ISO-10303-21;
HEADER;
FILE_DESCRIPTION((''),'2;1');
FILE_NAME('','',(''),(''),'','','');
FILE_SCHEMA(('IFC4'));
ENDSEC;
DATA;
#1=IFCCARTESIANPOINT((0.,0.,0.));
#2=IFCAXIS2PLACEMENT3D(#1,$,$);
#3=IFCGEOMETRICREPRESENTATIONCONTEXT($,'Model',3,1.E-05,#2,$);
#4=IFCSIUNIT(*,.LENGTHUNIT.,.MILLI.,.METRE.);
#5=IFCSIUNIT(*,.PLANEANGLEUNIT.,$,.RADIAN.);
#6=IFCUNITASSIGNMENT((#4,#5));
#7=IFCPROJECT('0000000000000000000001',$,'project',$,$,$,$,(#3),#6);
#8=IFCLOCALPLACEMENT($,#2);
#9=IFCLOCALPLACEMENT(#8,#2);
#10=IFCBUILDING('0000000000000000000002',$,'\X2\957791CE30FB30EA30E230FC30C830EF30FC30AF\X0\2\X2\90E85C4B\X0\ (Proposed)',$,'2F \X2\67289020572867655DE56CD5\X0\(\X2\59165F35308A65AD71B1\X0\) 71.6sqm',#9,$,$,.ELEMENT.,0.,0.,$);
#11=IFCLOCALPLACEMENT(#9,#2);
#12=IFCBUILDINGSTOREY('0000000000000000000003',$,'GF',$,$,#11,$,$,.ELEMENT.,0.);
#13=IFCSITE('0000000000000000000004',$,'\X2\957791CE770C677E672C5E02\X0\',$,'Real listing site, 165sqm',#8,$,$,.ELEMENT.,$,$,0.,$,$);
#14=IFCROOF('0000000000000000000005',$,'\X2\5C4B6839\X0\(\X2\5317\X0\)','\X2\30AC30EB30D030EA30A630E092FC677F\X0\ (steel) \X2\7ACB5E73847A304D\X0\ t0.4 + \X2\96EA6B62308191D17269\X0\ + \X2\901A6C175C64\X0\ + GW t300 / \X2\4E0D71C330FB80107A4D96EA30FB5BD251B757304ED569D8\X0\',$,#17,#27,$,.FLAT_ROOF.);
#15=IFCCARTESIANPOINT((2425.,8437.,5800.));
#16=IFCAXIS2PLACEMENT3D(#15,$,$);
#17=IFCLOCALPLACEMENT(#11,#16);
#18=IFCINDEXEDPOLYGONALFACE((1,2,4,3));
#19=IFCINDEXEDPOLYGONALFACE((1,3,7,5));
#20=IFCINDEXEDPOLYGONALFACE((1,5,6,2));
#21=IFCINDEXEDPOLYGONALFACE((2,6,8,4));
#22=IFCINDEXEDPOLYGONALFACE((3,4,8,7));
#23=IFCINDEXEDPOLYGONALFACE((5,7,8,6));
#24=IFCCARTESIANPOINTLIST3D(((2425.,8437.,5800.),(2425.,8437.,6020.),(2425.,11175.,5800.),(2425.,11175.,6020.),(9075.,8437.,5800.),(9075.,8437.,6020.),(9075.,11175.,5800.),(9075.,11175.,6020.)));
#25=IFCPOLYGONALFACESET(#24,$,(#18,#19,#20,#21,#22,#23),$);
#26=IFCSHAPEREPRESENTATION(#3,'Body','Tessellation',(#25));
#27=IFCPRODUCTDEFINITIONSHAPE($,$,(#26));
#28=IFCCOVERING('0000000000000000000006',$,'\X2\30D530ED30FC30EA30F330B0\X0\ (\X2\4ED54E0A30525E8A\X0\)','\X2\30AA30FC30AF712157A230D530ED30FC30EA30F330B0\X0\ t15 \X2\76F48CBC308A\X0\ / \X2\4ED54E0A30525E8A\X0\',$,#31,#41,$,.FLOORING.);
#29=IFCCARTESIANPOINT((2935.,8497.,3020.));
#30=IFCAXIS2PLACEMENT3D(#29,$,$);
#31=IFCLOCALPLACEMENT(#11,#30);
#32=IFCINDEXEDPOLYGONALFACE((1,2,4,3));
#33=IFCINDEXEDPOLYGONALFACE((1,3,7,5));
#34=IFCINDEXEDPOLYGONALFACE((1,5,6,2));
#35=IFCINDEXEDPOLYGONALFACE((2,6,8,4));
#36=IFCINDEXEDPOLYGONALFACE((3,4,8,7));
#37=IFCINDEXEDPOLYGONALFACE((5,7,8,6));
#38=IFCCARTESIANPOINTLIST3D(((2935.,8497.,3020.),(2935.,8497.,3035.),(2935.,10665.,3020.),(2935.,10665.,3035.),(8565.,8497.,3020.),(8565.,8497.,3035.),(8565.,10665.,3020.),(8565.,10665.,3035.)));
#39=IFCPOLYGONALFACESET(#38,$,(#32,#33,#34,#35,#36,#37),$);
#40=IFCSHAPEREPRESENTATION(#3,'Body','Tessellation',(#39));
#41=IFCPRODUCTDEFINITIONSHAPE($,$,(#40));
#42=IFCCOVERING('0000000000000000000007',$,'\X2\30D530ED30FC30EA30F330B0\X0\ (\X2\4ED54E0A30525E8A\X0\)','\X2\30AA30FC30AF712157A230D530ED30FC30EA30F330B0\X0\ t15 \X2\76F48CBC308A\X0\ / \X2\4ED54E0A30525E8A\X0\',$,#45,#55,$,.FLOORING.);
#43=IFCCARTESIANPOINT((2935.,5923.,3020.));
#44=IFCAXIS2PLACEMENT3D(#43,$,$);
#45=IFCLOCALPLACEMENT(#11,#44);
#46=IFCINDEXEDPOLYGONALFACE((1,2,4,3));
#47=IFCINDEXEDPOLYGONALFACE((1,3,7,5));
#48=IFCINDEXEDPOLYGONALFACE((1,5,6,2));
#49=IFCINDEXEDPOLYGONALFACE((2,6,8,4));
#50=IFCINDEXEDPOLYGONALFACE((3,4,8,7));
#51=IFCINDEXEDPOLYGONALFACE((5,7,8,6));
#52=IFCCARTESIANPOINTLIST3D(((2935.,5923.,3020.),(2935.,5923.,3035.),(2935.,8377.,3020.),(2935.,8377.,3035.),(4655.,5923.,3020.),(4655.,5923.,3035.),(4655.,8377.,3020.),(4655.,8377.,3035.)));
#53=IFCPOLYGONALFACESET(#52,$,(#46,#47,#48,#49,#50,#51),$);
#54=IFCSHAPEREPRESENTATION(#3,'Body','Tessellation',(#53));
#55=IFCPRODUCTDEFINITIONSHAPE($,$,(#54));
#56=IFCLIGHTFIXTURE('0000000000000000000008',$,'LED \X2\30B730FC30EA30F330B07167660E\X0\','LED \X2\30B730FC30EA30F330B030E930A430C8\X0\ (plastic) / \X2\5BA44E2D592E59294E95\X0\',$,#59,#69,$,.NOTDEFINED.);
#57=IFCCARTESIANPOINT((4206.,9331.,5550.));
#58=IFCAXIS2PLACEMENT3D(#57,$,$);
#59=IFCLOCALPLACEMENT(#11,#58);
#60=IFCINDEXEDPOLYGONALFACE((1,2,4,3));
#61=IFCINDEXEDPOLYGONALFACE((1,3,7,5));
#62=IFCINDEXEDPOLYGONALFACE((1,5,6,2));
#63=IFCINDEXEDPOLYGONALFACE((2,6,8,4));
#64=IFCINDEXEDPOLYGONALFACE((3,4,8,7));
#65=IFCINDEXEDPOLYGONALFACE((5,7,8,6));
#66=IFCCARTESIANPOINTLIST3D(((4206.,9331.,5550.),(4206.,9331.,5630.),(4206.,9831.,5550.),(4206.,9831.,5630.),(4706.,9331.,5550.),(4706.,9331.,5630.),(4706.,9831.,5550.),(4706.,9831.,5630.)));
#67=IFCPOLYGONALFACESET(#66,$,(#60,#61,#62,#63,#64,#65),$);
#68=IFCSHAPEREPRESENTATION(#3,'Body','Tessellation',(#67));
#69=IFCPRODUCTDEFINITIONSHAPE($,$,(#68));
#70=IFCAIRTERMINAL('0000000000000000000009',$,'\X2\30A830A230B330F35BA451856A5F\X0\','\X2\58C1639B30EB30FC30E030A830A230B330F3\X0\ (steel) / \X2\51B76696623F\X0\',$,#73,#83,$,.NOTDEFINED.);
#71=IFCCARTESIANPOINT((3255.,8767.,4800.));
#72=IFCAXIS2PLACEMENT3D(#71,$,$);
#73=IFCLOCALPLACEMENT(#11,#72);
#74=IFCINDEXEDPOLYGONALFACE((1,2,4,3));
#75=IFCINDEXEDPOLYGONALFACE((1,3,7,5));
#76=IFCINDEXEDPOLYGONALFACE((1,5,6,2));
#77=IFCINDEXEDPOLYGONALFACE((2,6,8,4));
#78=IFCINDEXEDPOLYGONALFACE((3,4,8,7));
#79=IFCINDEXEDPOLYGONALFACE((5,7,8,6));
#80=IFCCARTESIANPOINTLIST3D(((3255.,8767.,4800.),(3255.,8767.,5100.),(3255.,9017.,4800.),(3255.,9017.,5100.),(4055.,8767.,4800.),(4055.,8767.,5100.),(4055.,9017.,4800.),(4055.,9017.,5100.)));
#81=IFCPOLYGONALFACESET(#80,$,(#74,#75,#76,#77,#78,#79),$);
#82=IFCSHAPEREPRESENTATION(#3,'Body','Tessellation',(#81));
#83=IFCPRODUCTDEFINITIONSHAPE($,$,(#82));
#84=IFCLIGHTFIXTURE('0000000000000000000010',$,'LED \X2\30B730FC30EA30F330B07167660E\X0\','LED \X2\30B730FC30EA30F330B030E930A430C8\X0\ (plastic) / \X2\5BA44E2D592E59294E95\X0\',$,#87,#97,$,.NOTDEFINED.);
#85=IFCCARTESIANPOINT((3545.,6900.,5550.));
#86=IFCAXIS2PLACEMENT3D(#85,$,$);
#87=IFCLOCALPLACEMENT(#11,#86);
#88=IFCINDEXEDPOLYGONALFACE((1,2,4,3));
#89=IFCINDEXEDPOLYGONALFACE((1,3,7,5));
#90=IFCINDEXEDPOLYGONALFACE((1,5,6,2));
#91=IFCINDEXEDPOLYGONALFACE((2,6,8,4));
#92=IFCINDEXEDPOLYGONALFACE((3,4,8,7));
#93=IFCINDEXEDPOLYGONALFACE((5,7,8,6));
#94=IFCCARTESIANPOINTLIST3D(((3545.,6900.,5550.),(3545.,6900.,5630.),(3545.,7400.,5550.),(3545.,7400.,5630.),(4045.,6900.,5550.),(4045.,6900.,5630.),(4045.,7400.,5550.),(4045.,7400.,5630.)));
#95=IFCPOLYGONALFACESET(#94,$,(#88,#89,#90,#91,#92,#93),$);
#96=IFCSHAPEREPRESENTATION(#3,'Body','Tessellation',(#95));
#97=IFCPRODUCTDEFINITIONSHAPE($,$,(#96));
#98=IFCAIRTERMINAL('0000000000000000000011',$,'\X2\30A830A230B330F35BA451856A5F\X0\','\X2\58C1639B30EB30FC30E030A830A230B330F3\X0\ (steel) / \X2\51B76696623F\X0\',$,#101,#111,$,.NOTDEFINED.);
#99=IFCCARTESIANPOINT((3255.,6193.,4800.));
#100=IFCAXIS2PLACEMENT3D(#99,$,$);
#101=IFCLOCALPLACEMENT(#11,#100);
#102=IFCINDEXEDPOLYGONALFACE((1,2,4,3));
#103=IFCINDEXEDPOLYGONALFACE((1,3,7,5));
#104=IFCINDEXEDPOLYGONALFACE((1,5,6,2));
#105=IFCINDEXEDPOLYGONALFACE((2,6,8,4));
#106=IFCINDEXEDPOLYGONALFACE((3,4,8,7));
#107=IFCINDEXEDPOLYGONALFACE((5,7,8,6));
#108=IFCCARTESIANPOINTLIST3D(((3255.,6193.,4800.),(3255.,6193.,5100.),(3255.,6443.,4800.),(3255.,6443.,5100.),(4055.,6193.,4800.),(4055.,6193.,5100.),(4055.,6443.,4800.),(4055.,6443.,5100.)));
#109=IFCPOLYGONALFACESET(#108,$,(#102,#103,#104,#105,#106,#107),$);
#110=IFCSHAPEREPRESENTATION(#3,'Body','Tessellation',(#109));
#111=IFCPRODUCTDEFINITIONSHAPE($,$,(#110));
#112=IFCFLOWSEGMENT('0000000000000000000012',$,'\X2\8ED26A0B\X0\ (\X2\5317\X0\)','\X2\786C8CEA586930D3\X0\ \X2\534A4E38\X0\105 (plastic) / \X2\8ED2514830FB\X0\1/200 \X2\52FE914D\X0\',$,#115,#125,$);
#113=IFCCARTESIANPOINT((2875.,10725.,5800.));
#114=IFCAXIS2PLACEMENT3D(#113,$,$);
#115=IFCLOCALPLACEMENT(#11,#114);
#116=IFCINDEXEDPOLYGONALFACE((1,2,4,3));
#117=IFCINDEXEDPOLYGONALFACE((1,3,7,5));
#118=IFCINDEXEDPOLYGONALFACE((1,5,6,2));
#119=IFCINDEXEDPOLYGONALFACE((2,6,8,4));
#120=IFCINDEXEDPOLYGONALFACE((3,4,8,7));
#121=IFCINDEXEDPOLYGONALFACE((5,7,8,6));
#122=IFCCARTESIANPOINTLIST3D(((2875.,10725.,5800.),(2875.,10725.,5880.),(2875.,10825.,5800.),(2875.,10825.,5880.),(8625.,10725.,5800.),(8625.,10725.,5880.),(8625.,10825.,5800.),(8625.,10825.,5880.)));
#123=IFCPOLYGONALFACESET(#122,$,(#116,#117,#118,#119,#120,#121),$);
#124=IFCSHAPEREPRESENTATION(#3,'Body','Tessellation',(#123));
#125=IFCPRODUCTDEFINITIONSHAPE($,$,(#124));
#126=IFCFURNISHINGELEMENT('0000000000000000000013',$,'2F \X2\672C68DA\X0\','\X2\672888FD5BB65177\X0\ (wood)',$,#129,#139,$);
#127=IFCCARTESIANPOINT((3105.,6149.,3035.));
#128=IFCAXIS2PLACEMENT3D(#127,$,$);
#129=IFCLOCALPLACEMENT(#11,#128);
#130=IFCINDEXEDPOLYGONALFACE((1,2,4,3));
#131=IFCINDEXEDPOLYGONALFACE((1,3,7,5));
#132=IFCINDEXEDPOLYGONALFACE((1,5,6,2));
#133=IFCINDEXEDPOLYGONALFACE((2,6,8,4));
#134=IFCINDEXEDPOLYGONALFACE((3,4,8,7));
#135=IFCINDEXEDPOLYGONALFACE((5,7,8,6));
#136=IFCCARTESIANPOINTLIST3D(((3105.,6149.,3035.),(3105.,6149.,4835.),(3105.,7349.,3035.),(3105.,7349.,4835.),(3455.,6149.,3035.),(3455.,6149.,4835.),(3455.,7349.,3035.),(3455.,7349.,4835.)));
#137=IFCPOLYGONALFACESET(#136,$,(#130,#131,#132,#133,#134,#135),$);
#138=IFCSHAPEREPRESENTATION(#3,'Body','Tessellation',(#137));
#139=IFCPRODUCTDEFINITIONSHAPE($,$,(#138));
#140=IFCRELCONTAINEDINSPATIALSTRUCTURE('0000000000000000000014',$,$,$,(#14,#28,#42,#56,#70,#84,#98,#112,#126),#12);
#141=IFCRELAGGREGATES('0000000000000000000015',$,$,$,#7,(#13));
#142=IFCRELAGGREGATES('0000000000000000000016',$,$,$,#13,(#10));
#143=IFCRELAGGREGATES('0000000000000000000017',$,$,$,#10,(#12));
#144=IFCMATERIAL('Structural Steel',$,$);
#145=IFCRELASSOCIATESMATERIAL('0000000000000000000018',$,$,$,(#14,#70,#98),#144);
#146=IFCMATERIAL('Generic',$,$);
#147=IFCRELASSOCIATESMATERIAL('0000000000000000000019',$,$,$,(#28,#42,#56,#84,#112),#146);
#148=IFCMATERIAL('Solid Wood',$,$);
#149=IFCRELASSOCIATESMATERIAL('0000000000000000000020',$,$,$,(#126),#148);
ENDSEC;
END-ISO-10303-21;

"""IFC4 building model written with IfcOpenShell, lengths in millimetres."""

from ifc_helpers import new_model, si_unit, frame, frame_2d, origin, place, context, project, spatial, rectangle, extrude, material, element, save


model = new_model("IFC4")

# Units and contexts
model_context = context("Model", 3, precision=1e-05, world=origin())
ifc_project = project(units=[si_unit("LENGTHUNIT", "METRE", prefix="MILLI"), si_unit("PLANEANGLEUNIT", "RADIAN")], contexts=[model_context])

# Site, building, storey
site_placement = place(None, origin())
site = spatial("IfcSite", under=ifc_project, at=site_placement, Name="長野県松本市", ObjectType="Real listing site, 165sqm", CompositionType="ELEMENT", RefElevation=0.0)
building_placement = place(site_placement, origin())
building = spatial("IfcBuilding", under=site, at=building_placement, Name="長野・リモートワーク2部屋 (Proposed)", ObjectType="2F 木造在来工法(外張り断熱) 71.6sqm", CompositionType="ELEMENT", ElevationOfRefHeight=0.0, ElevationOfTerrain=0.0)
storey_placement = place(building_placement, origin())
storey = spatial("IfcBuildingStorey", under=building, at=storey_placement, Name="GF", CompositionType="ELEMENT", Elevation=0.0)

# Shared definitions
ifc_material_1 = material(Name="Solid Wood")

# Roof
ifc_material_2 = material(Name="Structural Steel")
for number, where, name in (
    (1, (2425.0, 8437.0, 5800.0), "屋根(北)"),
):
    element("IfcRoof", number, at=place(storey_placement, frame(where)), inside=storey, material=ifc_material_2, Name=name, Description="ガルバリウム鋼板 (steel) 立平葺き t0.4 + 雪止め金物 + 通気層 + GW t300 / 不燃・耐積雪・寒冷地仕様", PredefinedType="FLAT_ROOF", context=model_context, shape_type="SweptSolid", body=[
        extrude(rectangle(XDim=6650.0, YDim=2738.0, at=frame_2d((3325.0, 1369.0))), frame((2425.0, 8437.0, 5800.0)), (0.0, 0.0, 1.0), 220.0),
    ])

# Coverings
ifc_material_3 = material(Name="Generic")
covering_1_placement = place(storey_placement, frame((2935.0, 8497.0, 3020.0)))
element("IfcCovering", 2, at=covering_1_placement, inside=storey, material=ifc_material_3, Name="フローリング (仕上げ床)", Description="オーク無垢フローリング t15 直貼り / 仕上げ床", PredefinedType="FLOORING", context=model_context, shape_type="SweptSolid", body=[
    extrude(rectangle(XDim=5630.0, YDim=2168.0, at=frame_2d((2815.0, 1084.0))), frame((2935.0, 8497.0, 3020.0)), (0.0, 0.0, 1.0), 15.0),
])
covering_2_placement = place(storey_placement, frame((2935.0, 5923.0, 3020.0)))
element("IfcCovering", 3, at=covering_2_placement, inside=storey, material=ifc_material_3, Name="フローリング (仕上げ床)", Description="オーク無垢フローリング t15 直貼り / 仕上げ床", PredefinedType="FLOORING", context=model_context, shape_type="SweptSolid", body=[
    extrude(rectangle(XDim=1720.0, YDim=2454.0, at=frame_2d((860.0, 1227.0))), frame((2935.0, 5923.0, 3020.0)), (0.0, 0.0, 1.0), 15.0),
])

# Light fixture
light_fixture_1_placement = place(storey_placement, frame((4206.0, 9331.0, 5550.0)))
element("IfcLightFixture", 4, at=light_fixture_1_placement, inside=storey, material=ifc_material_3, Name="LED シーリング照明", Description="LED シーリングライト (plastic) / 室中央天井", PredefinedType="NOTDEFINED", context=model_context, shape_type="SweptSolid", body=[
    extrude(rectangle(XDim=500.0, YDim=500.0, at=frame_2d((250.0, 250.0))), frame((4206.0, 9331.0, 5550.0)), (0.0, 0.0, 1.0), 80.0),
])

# Air terminal
air_terminal_1_placement = place(storey_placement, frame((3255.0, 8767.0, 4800.0)))
element("IfcAirTerminal", 5, at=air_terminal_1_placement, inside=storey, material=ifc_material_2, Name="エアコン室内機", Description="壁掛ルームエアコン (steel) / 冷暖房", PredefinedType="NOTDEFINED", context=model_context, shape_type="SweptSolid", body=[
    extrude(rectangle(XDim=800.0, YDim=250.0, at=frame_2d((400.0, 125.0))), frame((3255.0, 8767.0, 4800.0)), (0.0, 0.0, 1.0), 300.0),
])

# Light fixture
light_fixture_2_placement = place(storey_placement, frame((3545.0, 6900.0, 5550.0)))
element("IfcLightFixture", 6, at=light_fixture_2_placement, inside=storey, material=ifc_material_3, Name="LED シーリング照明", Description="LED シーリングライト (plastic) / 室中央天井", PredefinedType="NOTDEFINED", context=model_context, shape_type="SweptSolid", body=[
    extrude(rectangle(XDim=500.0, YDim=500.0, at=frame_2d((250.0, 250.0))), frame((3545.0, 6900.0, 5550.0)), (0.0, 0.0, 1.0), 80.0),
])

# Air terminal
air_terminal_2_placement = place(storey_placement, frame((3255.0, 6193.0, 4800.0)))
element("IfcAirTerminal", 7, at=air_terminal_2_placement, inside=storey, material=ifc_material_2, Name="エアコン室内機", Description="壁掛ルームエアコン (steel) / 冷暖房", PredefinedType="NOTDEFINED", context=model_context, shape_type="SweptSolid", body=[
    extrude(rectangle(XDim=800.0, YDim=250.0, at=frame_2d((400.0, 125.0))), frame((3255.0, 6193.0, 4800.0)), (0.0, 0.0, 1.0), 300.0),
])

# Flow segment
flow_segment_placement = place(storey_placement, frame((2875.0, 10725.0, 5800.0)))
element("IfcFlowSegment", 8, at=flow_segment_placement, inside=storey, material=ifc_material_3, Name="軒樋 (北)", Description="硬質塩ビ 半丸105 (plastic) / 軒先・1/200 勾配", context=model_context, shape_type="SweptSolid", body=[
    extrude(rectangle(XDim=5750.0, YDim=100.0, at=frame_2d((2875.0, 50.0))), frame((2875.0, 10725.0, 5800.0)), (0.0, 0.0, 1.0), 80.0),
])

# Furnishing element
furnishing_placement = place(storey_placement, frame((3105.0, 6149.0, 3035.0)))
element("IfcFurnishingElement", 9, at=furnishing_placement, inside=storey, material=ifc_material_1, Name="2F 本棚", Description="木製家具 (wood)", context=model_context, shape_type="SweptSolid", body=[
    extrude(rectangle(XDim=350.0, YDim=1200.0, at=frame_2d((175.0, 600.0))), frame((3105.0, 6149.0, 3035.0)), (0.0, 0.0, 1.0), 1800.0),
])

save(model, "model.ifc")
